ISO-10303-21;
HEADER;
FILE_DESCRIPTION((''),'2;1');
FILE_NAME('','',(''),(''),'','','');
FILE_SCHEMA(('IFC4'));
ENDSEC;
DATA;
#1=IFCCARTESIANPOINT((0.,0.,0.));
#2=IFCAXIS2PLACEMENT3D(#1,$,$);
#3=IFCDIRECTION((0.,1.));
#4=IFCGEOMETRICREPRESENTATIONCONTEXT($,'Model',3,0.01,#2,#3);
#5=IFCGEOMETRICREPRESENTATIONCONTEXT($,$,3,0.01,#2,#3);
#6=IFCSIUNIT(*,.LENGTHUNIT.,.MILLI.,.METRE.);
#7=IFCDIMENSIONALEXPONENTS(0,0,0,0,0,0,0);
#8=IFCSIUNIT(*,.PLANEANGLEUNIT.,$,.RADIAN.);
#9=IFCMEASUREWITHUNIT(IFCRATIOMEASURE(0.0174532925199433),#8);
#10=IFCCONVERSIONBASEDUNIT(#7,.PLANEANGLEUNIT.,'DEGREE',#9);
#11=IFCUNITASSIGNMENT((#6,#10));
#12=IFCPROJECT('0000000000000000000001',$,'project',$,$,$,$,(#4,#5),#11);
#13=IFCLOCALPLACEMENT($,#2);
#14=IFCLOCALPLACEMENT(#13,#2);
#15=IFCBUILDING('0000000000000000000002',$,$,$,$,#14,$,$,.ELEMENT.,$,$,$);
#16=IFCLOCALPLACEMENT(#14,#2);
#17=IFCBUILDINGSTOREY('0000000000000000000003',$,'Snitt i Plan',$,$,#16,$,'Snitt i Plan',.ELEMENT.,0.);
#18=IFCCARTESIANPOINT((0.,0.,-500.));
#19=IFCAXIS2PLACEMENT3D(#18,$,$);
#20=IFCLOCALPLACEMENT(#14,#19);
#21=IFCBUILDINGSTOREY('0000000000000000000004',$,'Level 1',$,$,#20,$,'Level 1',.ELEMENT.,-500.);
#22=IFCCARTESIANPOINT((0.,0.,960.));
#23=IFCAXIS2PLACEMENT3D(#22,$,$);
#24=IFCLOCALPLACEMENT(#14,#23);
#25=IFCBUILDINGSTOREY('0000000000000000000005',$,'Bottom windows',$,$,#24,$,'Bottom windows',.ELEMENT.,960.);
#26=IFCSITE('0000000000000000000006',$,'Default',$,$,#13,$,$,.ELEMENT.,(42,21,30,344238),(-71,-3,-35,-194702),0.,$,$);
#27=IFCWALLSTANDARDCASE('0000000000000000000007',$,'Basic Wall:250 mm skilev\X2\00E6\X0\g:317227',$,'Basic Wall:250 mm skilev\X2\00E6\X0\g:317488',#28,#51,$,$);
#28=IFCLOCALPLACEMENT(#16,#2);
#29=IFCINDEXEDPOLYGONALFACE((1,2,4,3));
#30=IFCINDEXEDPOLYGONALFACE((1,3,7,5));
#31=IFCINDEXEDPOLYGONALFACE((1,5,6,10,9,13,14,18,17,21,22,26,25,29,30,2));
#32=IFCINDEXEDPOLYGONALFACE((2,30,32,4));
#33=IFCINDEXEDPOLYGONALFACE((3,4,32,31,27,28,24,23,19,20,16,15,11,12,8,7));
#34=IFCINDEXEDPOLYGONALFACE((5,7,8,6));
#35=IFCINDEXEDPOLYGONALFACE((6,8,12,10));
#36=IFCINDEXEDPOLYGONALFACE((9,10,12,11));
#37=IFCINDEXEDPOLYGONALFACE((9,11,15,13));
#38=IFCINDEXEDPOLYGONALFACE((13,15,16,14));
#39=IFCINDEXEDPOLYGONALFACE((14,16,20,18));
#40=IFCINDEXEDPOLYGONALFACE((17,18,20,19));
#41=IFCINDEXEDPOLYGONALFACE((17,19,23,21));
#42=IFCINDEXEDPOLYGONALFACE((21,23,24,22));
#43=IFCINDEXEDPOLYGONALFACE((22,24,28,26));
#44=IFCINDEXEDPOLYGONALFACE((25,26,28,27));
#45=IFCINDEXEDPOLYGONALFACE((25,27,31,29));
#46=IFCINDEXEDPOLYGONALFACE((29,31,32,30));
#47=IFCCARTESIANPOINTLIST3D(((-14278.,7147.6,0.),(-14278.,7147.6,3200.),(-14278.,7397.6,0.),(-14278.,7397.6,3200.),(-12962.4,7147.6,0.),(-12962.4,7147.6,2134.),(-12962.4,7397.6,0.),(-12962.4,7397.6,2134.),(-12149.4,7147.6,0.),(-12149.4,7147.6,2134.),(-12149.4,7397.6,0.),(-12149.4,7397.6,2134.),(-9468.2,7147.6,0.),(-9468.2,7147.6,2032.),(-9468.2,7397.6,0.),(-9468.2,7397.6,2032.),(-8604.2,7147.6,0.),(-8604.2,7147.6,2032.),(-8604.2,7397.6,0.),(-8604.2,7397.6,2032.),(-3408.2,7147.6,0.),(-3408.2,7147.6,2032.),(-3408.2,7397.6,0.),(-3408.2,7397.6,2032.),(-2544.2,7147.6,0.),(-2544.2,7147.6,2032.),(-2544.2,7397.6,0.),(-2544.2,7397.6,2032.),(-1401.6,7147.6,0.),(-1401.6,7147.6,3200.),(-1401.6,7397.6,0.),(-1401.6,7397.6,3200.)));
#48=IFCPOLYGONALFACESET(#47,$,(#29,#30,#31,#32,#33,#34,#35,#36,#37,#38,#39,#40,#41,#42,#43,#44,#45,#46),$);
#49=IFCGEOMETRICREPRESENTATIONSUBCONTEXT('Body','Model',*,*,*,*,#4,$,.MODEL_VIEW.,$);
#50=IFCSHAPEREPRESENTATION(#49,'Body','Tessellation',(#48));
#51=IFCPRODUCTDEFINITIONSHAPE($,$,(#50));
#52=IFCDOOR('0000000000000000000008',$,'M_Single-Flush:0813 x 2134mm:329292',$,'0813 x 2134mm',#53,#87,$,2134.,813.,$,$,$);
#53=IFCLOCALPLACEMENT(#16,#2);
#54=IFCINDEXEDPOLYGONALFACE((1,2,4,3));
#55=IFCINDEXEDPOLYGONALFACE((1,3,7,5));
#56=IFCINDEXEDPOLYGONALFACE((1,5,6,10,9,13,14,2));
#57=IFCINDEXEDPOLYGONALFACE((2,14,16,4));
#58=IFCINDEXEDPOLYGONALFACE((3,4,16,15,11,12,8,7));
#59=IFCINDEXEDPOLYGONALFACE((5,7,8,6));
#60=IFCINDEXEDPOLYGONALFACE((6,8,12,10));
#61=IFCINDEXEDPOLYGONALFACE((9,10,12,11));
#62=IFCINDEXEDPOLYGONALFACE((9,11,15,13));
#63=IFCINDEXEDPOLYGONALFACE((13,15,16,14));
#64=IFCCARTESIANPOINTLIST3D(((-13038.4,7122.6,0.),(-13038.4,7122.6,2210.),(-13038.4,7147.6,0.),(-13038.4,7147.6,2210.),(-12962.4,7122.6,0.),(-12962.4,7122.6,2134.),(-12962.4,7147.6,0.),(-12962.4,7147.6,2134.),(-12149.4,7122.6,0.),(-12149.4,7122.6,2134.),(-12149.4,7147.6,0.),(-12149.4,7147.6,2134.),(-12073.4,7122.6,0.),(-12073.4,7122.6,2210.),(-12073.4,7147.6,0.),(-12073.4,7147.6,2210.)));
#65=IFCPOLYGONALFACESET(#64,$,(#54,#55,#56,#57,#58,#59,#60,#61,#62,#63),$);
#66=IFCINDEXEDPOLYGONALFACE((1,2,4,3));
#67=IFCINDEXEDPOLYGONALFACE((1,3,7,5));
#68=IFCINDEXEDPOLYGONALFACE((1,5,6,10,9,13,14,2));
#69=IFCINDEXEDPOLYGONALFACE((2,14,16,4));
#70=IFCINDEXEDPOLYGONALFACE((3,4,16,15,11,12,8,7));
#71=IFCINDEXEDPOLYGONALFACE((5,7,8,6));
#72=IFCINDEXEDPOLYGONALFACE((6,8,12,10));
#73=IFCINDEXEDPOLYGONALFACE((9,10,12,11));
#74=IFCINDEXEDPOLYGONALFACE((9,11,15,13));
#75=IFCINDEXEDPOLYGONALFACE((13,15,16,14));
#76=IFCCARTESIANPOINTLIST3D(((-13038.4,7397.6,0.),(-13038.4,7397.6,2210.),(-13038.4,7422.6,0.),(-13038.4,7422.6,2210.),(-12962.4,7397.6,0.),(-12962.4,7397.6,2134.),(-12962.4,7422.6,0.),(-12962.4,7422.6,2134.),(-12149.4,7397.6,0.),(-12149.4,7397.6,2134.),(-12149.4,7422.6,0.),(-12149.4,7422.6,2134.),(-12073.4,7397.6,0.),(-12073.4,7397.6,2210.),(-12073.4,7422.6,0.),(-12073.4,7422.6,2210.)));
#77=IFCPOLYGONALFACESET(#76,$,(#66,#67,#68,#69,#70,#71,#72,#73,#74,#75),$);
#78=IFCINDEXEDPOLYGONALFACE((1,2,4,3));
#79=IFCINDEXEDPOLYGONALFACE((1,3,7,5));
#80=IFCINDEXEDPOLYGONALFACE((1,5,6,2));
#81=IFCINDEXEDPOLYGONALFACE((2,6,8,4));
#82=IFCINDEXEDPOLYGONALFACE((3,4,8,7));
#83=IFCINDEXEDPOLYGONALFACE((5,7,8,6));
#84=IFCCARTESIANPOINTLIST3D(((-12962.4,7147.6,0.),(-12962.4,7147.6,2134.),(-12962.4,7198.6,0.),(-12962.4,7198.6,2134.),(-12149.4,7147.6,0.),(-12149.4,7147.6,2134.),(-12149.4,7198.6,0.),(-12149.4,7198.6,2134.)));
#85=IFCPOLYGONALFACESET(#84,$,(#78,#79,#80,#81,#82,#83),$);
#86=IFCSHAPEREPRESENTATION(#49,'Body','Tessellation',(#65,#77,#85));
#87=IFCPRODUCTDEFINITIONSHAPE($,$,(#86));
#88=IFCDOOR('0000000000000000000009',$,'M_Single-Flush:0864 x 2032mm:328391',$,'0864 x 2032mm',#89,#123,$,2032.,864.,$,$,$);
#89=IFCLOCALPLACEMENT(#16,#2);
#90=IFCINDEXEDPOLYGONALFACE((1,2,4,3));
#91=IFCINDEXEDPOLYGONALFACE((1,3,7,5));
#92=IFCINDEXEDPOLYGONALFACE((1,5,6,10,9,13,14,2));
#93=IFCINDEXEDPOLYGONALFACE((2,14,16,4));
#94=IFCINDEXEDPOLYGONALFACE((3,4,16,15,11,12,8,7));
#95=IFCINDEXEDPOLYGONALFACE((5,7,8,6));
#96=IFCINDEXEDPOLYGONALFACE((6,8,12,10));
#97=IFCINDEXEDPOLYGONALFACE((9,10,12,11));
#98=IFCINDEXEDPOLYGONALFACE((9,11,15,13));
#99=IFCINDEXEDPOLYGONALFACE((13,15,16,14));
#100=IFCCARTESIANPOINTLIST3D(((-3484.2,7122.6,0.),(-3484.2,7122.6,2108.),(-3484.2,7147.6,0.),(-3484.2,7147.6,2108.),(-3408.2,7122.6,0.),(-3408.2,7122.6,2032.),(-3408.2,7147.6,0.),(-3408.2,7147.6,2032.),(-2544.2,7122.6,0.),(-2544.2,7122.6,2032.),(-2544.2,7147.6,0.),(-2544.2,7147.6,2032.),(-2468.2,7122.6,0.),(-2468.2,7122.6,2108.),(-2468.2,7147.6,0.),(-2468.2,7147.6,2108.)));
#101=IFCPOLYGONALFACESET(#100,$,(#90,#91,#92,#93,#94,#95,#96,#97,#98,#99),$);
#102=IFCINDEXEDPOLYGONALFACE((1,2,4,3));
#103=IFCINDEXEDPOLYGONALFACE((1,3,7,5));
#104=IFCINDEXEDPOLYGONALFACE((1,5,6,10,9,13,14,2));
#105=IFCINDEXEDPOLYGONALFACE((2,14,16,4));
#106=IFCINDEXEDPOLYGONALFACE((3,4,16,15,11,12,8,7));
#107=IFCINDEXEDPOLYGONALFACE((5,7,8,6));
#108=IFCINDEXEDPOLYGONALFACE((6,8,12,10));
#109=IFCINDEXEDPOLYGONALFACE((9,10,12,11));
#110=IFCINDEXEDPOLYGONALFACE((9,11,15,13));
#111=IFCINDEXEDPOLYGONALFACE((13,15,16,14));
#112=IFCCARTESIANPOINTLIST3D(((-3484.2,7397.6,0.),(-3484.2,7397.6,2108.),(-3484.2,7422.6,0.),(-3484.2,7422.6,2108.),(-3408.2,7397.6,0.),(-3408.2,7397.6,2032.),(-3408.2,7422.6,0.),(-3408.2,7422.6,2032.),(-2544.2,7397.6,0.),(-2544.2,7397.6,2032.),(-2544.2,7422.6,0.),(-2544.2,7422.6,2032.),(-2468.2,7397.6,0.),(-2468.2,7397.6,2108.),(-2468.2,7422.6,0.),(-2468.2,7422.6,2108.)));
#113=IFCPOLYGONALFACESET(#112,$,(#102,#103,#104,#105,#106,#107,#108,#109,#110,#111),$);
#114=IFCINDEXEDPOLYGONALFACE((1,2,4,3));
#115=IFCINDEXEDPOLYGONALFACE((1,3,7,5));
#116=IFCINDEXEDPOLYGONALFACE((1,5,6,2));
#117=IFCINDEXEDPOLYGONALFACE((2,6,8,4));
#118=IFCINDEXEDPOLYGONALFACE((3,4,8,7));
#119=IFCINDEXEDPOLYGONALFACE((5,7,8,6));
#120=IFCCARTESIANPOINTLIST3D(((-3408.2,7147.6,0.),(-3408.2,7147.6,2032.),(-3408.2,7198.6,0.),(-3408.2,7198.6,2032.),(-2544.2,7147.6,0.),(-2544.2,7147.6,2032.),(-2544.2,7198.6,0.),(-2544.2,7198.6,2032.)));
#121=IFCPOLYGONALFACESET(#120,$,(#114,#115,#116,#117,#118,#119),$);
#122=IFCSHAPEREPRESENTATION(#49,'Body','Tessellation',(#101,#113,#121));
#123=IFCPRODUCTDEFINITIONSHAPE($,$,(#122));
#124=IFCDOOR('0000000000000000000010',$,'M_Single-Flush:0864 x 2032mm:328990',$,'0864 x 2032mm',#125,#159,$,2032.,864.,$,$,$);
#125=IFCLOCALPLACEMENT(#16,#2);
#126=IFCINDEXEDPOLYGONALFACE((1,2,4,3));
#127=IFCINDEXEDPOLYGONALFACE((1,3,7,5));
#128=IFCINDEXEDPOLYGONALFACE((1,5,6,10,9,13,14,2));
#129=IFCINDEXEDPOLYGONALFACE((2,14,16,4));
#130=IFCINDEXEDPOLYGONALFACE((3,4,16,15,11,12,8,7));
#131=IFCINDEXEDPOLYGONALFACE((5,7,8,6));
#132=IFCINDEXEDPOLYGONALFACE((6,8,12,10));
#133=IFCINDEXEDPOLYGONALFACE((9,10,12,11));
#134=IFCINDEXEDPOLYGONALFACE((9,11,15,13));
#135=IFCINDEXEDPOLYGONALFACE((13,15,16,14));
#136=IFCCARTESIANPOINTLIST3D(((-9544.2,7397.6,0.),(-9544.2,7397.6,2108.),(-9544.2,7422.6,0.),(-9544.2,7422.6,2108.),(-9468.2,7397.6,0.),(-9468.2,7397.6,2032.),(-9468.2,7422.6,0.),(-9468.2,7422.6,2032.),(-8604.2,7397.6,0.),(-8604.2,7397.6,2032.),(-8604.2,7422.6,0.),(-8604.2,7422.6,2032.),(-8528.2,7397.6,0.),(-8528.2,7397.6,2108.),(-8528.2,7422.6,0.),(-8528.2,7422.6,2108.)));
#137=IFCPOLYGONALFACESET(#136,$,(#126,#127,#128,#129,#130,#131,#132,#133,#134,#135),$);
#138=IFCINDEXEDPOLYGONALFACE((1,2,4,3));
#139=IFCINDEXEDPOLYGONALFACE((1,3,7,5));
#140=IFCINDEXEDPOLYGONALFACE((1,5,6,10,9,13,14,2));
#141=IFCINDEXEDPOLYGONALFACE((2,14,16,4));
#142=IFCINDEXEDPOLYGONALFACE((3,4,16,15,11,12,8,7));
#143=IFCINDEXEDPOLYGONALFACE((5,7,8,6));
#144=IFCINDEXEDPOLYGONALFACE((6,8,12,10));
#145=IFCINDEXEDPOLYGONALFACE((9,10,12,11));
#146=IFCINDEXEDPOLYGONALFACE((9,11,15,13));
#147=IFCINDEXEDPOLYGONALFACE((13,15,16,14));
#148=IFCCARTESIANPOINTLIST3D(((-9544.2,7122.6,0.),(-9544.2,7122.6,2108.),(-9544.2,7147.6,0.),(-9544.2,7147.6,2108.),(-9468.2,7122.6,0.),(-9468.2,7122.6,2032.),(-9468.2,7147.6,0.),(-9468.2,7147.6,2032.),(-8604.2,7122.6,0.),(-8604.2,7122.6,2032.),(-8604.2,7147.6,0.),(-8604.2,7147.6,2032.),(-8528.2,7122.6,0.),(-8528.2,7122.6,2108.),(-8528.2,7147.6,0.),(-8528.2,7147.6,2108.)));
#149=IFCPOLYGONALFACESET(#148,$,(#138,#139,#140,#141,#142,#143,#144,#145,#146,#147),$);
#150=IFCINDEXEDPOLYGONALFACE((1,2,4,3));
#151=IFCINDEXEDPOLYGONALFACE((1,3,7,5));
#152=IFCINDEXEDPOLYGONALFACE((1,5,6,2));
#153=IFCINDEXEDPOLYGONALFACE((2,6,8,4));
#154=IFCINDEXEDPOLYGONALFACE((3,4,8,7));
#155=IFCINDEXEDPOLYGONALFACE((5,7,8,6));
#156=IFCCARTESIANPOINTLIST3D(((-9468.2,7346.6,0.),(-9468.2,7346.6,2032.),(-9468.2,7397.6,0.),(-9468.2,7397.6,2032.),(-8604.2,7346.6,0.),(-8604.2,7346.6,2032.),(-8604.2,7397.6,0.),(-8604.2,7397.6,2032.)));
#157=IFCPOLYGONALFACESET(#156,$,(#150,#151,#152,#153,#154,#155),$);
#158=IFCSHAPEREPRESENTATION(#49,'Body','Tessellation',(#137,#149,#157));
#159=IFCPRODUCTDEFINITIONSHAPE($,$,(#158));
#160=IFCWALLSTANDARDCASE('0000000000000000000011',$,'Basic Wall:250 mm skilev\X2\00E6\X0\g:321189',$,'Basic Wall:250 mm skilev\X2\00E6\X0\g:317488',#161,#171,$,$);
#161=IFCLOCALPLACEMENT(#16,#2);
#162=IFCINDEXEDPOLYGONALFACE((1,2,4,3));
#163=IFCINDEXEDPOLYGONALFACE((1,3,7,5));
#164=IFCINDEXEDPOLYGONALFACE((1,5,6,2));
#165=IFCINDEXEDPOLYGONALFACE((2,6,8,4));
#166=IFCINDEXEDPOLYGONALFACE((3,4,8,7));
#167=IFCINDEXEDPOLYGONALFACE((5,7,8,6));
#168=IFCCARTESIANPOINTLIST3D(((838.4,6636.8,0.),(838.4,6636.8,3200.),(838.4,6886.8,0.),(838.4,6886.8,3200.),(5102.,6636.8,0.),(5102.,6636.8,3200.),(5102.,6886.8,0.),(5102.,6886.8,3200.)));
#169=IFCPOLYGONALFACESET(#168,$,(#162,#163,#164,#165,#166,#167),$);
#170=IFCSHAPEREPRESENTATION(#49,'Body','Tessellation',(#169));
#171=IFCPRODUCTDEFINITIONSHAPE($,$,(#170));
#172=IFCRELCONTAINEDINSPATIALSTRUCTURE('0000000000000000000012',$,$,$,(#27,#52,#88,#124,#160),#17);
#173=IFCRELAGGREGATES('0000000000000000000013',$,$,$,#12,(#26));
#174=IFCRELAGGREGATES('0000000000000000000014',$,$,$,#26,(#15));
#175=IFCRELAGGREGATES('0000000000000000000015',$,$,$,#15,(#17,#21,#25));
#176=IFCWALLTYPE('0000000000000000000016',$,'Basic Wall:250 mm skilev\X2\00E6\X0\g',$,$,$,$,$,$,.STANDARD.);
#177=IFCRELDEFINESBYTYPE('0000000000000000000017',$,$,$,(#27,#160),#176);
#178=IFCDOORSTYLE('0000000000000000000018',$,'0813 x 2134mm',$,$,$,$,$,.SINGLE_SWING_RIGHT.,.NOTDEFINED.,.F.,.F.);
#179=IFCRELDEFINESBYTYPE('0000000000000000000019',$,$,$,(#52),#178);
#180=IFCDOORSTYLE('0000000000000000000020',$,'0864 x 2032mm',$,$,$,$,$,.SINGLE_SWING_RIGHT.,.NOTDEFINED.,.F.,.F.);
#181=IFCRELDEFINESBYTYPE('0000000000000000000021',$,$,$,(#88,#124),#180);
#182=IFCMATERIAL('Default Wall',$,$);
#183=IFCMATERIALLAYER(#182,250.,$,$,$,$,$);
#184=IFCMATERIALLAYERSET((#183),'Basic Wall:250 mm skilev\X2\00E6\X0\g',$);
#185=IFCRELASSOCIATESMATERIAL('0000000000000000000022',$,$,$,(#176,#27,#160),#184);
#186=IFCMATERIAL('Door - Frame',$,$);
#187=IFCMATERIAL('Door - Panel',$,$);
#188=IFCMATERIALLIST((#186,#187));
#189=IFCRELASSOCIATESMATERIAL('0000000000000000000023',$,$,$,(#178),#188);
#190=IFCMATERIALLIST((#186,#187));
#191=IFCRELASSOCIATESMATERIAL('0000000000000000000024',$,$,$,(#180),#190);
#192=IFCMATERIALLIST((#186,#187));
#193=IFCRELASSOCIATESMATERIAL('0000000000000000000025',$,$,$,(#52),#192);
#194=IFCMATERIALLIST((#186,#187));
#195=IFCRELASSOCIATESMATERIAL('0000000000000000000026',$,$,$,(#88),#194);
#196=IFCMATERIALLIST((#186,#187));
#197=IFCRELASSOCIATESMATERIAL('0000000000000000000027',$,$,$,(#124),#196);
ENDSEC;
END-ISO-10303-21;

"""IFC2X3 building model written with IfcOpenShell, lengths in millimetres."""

from ifc_helpers import new_model, entity, si_unit, converted_unit, direction, frame, frame_2d, origin, place, context, subcontext, project, spatial, polyline, rectangle, outline, extrude, source, transform, mapped, material, material_list, layer, layer_set, layer_usage, type_object, type_shapes, element, fill, save


model = new_model("IFC2X3")

# Units and contexts
model_context = context("Model", 3, precision=0.01, world=origin(), true_north=direction((0.0, 1.0)))
context_of_model = context(None, 3, precision=0.01, world=origin(), true_north=direction((0.0, 1.0)))
body_context = subcontext(model_context, "Body", "Model", "MODEL_VIEW")
ifc_project = project(units=[si_unit("LENGTHUNIT", "METRE", prefix="MILLI"), converted_unit("PLANEANGLEUNIT", "DEGREE", entity("IfcRatioMeasure", 0.0174532925199433), si_unit("PLANEANGLEUNIT", "RADIAN"), dimensions=[0, 0, 0, 0, 0, 0, 0])], contexts=[model_context, context_of_model])

# Site, building, storey
site_placement = place(None, origin())
site = spatial("IfcSite", under=ifc_project, at=site_placement, Name="Default", CompositionType="ELEMENT", RefLatitude=(42, 21, 30, 344238), RefLongitude=(-71, -3, -35, -194702), RefElevation=0.0)
building_placement = place(site_placement, origin())
building = spatial("IfcBuilding", under=site, at=building_placement, CompositionType="ELEMENT")
storey_1_placement = place(building_placement, origin())
storey_1 = spatial("IfcBuildingStorey", under=building, at=storey_1_placement, Name="Snitt i Plan", LongName="Snitt i Plan", CompositionType="ELEMENT", Elevation=0.0)

# Shared definitions
ifc_material_1 = material(Name="Default Wall")
ifc_layer = layer(ifc_material_1, 250.0)
ifc_layer_set = layer_set([ifc_layer], Name="Basic Wall:250 mm skilevæg")
wall_type = type_object("IfcWallType", Name="Basic Wall:250 mm skilevæg", PredefinedType="STANDARD", material=ifc_layer_set)
ifc_material_2 = material(Name="Door - Frame")
ifc_material_3 = material(Name="Door - Panel")
ifc_material_list_1 = material_list([ifc_material_2, ifc_material_3])
door_style_1 = type_object("IfcDoorStyle", Name="0813 x 2134mm", ConstructionType="NOTDEFINED", OperationType="SINGLE_SWING_RIGHT", ParameterTakesPrecedence=False, Sizeable=False, material=ifc_material_list_1)
shared_shape_1 = source(origin(), body_context, "Body", "SweptSolid", [
    extrude(outline(polyline([(-482.5, -1124.0), (482.5, -1124.0), (482.5, 1086.0), (406.5, 1086.0), (406.5, -1048.0), (-406.5, -1048.0), (-406.5, 1086.0), (-482.5, 1086.0), (-482.5, -1124.0)])), frame((406.5, 250.0, 1086.0), z_axis=(0.0, 1.0, 0.0), x_axis=(1.0, 0.0, 0.0)), (0.0, 0.0, 1.0), 25.0),
    extrude(outline(polyline([(-1124.0, -482.5), (1086.0, -482.5), (1086.0, -406.5), (-1048.0, -406.5), (-1048.0, 406.5), (1086.0, 406.5), (1086.0, 482.5), (-1124.0, 482.5), (-1124.0, -482.5)])), frame((406.5, -25.0, 1086.0), z_axis=(0.0, 1.0, 0.0), x_axis=(0.0, 0.0, -1.0)), (0.0, 0.0, 1.0), 25.0),
    extrude(rectangle(XDim=51.0, YDim=813.0, at=frame_2d((0.0, 0.0), x_axis=(1.0, 0.0))), frame((406.5, 224.5, 0.0), z_axis=(0.0, 0.0, 1.0), x_axis=(0.0, 1.0, 0.0)), (0.0, 0.0, 1.0), 2134.0),
])
type_shapes(door_style_1, [shared_shape_1])
ifc_material_list_2 = material_list([ifc_material_2, ifc_material_3])
door_style_2 = type_object("IfcDoorStyle", Name="0864 x 2032mm", ConstructionType="NOTDEFINED", OperationType="SINGLE_SWING_RIGHT", ParameterTakesPrecedence=False, Sizeable=False, material=ifc_material_list_2)
shared_shape_2 = source(origin(), body_context, "Body", "SweptSolid", [
    extrude(outline(polyline([(-508.0, -1073.0), (508.0, -1073.0), (508.0, 1035.0), (432.0, 1035.0), (432.0, -997.0), (-432.0, -997.0), (-432.0, 1035.0), (-508.0, 1035.0), (-508.0, -1073.0)])), frame((432.0, 250.0, 1035.0), z_axis=(0.0, 1.0, 0.0), x_axis=(1.0, 0.0, 0.0)), (0.0, 0.0, 1.0), 25.0),
    extrude(outline(polyline([(-1073.0, -508.0), (1035.0, -508.0), (1035.0, -432.0), (-997.0, -432.0), (-997.0, 432.0), (1035.0, 432.0), (1035.0, 508.0), (-1073.0, 508.0), (-1073.0, -508.0)])), frame((432.0, -25.0, 1035.0), z_axis=(0.0, 1.0, 0.0), x_axis=(0.0, 0.0, -1.0)), (0.0, 0.0, 1.0), 25.0),
    extrude(rectangle(XDim=51.0, YDim=864.0, at=frame_2d((0.0, 0.0), x_axis=(1.0, 0.0))), frame((432.0, 224.5, 0.0), z_axis=(0.0, 0.0, 1.0), x_axis=(0.0, 1.0, 0.0)), (0.0, 0.0, 1.0), 2032.0),
])
type_shapes(door_style_2, [shared_shape_2])

# Shared definitions
storey_2_placement = place(building_placement, frame((0.0, 0.0, -500.0)))
storey_2 = spatial("IfcBuildingStorey", under=building, at=storey_2_placement, Name="Level 1", LongName="Level 1", CompositionType="ELEMENT", Elevation=-500.0)

# Shared definitions
storey_3_placement = place(building_placement, frame((0.0, 0.0, 960.0)))
storey_3 = spatial("IfcBuildingStorey", under=building, at=storey_3_placement, Name="Bottom windows", LongName="Bottom windows", CompositionType="ELEMENT", Elevation=960.0)

# Wall, openings, doors
ifc_layer_usage_1 = layer_usage(ifc_layer_set, "AXIS2", "NEGATIVE", 125.0)
wall_1_placement = place(storey_1_placement, frame((-1401.6, 7272.6, 0.0), z_axis=(0.0, 0.0, 1.0), x_axis=(-1.0, 0.0, 0.0)))
wall_1 = element("IfcWallStandardCase", 1, at=wall_1_placement, inside=storey_1, type_object=wall_type, material=ifc_layer_usage_1, Name="Basic Wall:250 mm skilevæg:317227", ObjectType="Basic Wall:250 mm skilevæg:317488", context=body_context, shape_type="SweptSolid", body=[
    extrude(rectangle(XDim=12876.4, YDim=250.0, at=frame_2d((6438.2, 0.0), x_axis=(-1.0, 0.0))), origin(), (0.0, 0.0, 1.0), 3200.0),
])
opening_1_placement = place(wall_1_placement, frame((1142.6, -125.0, 0.0)))
opening_1 = element("IfcOpeningElement", 2, at=opening_1_placement, cuts=wall_1, ObjectType="Opening", context=body_context, shape_type="SweptSolid", body=[
    extrude(rectangle(XDim=864.0, YDim=2032.0, at=frame_2d((1016.0, 432.0), x_axis=(0.0, 1.0))), frame((0.0, 0.0, 0.0), z_axis=(0.0, 1.0, 0.0), x_axis=(0.0, 0.0, 1.0)), (0.0, 0.0, 1.0), 250.0),
])
opening_2_placement = place(wall_1_placement, frame((8066.6, 125.0, 0.0)))
opening_2 = element("IfcOpeningElement", 3, at=opening_2_placement, cuts=wall_1, ObjectType="Opening", context=body_context, shape_type="SweptSolid", body=[
    extrude(rectangle(XDim=864.0, YDim=2032.0, at=frame_2d((1016.0, 432.0), x_axis=(0.0, 1.0))), frame((0.0, 0.0, 0.0), z_axis=(0.0, -1.0, 0.0), x_axis=(0.0, 0.0, 1.0)), (0.0, 0.0, 1.0), 250.0),
])
opening_3_placement = place(wall_1_placement, frame((10747.8, -125.0, 0.0)))
opening_3 = element("IfcOpeningElement", 4, at=opening_3_placement, cuts=wall_1, ObjectType="Opening", context=body_context, shape_type="SweptSolid", body=[
    extrude(rectangle(XDim=813.0, YDim=2134.0, at=frame_2d((1067.0, 406.5), x_axis=(0.0, 1.0))), frame((0.0, 0.0, 0.0), z_axis=(0.0, 1.0, 0.0), x_axis=(0.0, 0.0, 1.0)), (0.0, 0.0, 1.0), 250.0),
])
ifc_material_list_3 = material_list([ifc_material_2, ifc_material_3])
door_1_placement = place(opening_3_placement, origin())
door_1 = element("IfcDoor", 5, at=door_1_placement, inside=storey_1, type_object=door_style_1, material=ifc_material_list_3, Name="M_Single-Flush:0813 x 2134mm:329292", ObjectType="0813 x 2134mm", OverallHeight=2134.0, OverallWidth=813.0, context=body_context, shape_type="MappedRepresentation", body=[
    mapped(shared_shape_1, transform((0.0, 0.0, 0.0), scale=1.0)),
])
fill(opening_3, door_1)
ifc_material_list_4 = material_list([ifc_material_2, ifc_material_3])
door_2_placement = place(opening_1_placement, origin())
door_2 = element("IfcDoor", 6, at=door_2_placement, inside=storey_1, type_object=door_style_2, material=ifc_material_list_4, Name="M_Single-Flush:0864 x 2032mm:328391", ObjectType="0864 x 2032mm", OverallHeight=2032.0, OverallWidth=864.0, context=body_context, shape_type="MappedRepresentation", body=[
    mapped(shared_shape_2, transform((0.0, 0.0, 0.0), scale=1.0)),
])
fill(opening_1, door_2)
ifc_material_list_5 = material_list([ifc_material_2, ifc_material_3])
door_3_placement = place(opening_2_placement, frame((0.0, 0.0, 0.0), z_axis=(0.0, 0.0, 1.0), x_axis=(-1.0, 0.0, 0.0)))
door_3 = element("IfcDoor", 7, at=door_3_placement, inside=storey_1, type_object=door_style_2, material=ifc_material_list_5, Name="M_Single-Flush:0864 x 2032mm:328990", ObjectType="0864 x 2032mm", OverallHeight=2032.0, OverallWidth=864.0, context=body_context, shape_type="MappedRepresentation", body=[
    mapped(shared_shape_2, transform((0.0, 0.0, 0.0), scale=1.0)),
])
fill(opening_2, door_3)

# Wall
ifc_layer_usage_2 = layer_usage(ifc_layer_set, "AXIS2", "NEGATIVE", 125.0)
wall_2_placement = place(storey_1_placement, frame((838.4, 6761.8, 0.0)))
element("IfcWallStandardCase", 8, at=wall_2_placement, inside=storey_1, type_object=wall_type, material=ifc_layer_usage_2, Name="Basic Wall:250 mm skilevæg:321189", ObjectType="Basic Wall:250 mm skilevæg:317488", context=body_context, shape_type="SweptSolid", body=[
    extrude(rectangle(XDim=4263.6, YDim=250.0, at=frame_2d((2131.8, 0.0), x_axis=(-1.0, 0.0))), origin(), (0.0, 0.0, 1.0), 3200.0),
])

save(model, "model.ifc")
